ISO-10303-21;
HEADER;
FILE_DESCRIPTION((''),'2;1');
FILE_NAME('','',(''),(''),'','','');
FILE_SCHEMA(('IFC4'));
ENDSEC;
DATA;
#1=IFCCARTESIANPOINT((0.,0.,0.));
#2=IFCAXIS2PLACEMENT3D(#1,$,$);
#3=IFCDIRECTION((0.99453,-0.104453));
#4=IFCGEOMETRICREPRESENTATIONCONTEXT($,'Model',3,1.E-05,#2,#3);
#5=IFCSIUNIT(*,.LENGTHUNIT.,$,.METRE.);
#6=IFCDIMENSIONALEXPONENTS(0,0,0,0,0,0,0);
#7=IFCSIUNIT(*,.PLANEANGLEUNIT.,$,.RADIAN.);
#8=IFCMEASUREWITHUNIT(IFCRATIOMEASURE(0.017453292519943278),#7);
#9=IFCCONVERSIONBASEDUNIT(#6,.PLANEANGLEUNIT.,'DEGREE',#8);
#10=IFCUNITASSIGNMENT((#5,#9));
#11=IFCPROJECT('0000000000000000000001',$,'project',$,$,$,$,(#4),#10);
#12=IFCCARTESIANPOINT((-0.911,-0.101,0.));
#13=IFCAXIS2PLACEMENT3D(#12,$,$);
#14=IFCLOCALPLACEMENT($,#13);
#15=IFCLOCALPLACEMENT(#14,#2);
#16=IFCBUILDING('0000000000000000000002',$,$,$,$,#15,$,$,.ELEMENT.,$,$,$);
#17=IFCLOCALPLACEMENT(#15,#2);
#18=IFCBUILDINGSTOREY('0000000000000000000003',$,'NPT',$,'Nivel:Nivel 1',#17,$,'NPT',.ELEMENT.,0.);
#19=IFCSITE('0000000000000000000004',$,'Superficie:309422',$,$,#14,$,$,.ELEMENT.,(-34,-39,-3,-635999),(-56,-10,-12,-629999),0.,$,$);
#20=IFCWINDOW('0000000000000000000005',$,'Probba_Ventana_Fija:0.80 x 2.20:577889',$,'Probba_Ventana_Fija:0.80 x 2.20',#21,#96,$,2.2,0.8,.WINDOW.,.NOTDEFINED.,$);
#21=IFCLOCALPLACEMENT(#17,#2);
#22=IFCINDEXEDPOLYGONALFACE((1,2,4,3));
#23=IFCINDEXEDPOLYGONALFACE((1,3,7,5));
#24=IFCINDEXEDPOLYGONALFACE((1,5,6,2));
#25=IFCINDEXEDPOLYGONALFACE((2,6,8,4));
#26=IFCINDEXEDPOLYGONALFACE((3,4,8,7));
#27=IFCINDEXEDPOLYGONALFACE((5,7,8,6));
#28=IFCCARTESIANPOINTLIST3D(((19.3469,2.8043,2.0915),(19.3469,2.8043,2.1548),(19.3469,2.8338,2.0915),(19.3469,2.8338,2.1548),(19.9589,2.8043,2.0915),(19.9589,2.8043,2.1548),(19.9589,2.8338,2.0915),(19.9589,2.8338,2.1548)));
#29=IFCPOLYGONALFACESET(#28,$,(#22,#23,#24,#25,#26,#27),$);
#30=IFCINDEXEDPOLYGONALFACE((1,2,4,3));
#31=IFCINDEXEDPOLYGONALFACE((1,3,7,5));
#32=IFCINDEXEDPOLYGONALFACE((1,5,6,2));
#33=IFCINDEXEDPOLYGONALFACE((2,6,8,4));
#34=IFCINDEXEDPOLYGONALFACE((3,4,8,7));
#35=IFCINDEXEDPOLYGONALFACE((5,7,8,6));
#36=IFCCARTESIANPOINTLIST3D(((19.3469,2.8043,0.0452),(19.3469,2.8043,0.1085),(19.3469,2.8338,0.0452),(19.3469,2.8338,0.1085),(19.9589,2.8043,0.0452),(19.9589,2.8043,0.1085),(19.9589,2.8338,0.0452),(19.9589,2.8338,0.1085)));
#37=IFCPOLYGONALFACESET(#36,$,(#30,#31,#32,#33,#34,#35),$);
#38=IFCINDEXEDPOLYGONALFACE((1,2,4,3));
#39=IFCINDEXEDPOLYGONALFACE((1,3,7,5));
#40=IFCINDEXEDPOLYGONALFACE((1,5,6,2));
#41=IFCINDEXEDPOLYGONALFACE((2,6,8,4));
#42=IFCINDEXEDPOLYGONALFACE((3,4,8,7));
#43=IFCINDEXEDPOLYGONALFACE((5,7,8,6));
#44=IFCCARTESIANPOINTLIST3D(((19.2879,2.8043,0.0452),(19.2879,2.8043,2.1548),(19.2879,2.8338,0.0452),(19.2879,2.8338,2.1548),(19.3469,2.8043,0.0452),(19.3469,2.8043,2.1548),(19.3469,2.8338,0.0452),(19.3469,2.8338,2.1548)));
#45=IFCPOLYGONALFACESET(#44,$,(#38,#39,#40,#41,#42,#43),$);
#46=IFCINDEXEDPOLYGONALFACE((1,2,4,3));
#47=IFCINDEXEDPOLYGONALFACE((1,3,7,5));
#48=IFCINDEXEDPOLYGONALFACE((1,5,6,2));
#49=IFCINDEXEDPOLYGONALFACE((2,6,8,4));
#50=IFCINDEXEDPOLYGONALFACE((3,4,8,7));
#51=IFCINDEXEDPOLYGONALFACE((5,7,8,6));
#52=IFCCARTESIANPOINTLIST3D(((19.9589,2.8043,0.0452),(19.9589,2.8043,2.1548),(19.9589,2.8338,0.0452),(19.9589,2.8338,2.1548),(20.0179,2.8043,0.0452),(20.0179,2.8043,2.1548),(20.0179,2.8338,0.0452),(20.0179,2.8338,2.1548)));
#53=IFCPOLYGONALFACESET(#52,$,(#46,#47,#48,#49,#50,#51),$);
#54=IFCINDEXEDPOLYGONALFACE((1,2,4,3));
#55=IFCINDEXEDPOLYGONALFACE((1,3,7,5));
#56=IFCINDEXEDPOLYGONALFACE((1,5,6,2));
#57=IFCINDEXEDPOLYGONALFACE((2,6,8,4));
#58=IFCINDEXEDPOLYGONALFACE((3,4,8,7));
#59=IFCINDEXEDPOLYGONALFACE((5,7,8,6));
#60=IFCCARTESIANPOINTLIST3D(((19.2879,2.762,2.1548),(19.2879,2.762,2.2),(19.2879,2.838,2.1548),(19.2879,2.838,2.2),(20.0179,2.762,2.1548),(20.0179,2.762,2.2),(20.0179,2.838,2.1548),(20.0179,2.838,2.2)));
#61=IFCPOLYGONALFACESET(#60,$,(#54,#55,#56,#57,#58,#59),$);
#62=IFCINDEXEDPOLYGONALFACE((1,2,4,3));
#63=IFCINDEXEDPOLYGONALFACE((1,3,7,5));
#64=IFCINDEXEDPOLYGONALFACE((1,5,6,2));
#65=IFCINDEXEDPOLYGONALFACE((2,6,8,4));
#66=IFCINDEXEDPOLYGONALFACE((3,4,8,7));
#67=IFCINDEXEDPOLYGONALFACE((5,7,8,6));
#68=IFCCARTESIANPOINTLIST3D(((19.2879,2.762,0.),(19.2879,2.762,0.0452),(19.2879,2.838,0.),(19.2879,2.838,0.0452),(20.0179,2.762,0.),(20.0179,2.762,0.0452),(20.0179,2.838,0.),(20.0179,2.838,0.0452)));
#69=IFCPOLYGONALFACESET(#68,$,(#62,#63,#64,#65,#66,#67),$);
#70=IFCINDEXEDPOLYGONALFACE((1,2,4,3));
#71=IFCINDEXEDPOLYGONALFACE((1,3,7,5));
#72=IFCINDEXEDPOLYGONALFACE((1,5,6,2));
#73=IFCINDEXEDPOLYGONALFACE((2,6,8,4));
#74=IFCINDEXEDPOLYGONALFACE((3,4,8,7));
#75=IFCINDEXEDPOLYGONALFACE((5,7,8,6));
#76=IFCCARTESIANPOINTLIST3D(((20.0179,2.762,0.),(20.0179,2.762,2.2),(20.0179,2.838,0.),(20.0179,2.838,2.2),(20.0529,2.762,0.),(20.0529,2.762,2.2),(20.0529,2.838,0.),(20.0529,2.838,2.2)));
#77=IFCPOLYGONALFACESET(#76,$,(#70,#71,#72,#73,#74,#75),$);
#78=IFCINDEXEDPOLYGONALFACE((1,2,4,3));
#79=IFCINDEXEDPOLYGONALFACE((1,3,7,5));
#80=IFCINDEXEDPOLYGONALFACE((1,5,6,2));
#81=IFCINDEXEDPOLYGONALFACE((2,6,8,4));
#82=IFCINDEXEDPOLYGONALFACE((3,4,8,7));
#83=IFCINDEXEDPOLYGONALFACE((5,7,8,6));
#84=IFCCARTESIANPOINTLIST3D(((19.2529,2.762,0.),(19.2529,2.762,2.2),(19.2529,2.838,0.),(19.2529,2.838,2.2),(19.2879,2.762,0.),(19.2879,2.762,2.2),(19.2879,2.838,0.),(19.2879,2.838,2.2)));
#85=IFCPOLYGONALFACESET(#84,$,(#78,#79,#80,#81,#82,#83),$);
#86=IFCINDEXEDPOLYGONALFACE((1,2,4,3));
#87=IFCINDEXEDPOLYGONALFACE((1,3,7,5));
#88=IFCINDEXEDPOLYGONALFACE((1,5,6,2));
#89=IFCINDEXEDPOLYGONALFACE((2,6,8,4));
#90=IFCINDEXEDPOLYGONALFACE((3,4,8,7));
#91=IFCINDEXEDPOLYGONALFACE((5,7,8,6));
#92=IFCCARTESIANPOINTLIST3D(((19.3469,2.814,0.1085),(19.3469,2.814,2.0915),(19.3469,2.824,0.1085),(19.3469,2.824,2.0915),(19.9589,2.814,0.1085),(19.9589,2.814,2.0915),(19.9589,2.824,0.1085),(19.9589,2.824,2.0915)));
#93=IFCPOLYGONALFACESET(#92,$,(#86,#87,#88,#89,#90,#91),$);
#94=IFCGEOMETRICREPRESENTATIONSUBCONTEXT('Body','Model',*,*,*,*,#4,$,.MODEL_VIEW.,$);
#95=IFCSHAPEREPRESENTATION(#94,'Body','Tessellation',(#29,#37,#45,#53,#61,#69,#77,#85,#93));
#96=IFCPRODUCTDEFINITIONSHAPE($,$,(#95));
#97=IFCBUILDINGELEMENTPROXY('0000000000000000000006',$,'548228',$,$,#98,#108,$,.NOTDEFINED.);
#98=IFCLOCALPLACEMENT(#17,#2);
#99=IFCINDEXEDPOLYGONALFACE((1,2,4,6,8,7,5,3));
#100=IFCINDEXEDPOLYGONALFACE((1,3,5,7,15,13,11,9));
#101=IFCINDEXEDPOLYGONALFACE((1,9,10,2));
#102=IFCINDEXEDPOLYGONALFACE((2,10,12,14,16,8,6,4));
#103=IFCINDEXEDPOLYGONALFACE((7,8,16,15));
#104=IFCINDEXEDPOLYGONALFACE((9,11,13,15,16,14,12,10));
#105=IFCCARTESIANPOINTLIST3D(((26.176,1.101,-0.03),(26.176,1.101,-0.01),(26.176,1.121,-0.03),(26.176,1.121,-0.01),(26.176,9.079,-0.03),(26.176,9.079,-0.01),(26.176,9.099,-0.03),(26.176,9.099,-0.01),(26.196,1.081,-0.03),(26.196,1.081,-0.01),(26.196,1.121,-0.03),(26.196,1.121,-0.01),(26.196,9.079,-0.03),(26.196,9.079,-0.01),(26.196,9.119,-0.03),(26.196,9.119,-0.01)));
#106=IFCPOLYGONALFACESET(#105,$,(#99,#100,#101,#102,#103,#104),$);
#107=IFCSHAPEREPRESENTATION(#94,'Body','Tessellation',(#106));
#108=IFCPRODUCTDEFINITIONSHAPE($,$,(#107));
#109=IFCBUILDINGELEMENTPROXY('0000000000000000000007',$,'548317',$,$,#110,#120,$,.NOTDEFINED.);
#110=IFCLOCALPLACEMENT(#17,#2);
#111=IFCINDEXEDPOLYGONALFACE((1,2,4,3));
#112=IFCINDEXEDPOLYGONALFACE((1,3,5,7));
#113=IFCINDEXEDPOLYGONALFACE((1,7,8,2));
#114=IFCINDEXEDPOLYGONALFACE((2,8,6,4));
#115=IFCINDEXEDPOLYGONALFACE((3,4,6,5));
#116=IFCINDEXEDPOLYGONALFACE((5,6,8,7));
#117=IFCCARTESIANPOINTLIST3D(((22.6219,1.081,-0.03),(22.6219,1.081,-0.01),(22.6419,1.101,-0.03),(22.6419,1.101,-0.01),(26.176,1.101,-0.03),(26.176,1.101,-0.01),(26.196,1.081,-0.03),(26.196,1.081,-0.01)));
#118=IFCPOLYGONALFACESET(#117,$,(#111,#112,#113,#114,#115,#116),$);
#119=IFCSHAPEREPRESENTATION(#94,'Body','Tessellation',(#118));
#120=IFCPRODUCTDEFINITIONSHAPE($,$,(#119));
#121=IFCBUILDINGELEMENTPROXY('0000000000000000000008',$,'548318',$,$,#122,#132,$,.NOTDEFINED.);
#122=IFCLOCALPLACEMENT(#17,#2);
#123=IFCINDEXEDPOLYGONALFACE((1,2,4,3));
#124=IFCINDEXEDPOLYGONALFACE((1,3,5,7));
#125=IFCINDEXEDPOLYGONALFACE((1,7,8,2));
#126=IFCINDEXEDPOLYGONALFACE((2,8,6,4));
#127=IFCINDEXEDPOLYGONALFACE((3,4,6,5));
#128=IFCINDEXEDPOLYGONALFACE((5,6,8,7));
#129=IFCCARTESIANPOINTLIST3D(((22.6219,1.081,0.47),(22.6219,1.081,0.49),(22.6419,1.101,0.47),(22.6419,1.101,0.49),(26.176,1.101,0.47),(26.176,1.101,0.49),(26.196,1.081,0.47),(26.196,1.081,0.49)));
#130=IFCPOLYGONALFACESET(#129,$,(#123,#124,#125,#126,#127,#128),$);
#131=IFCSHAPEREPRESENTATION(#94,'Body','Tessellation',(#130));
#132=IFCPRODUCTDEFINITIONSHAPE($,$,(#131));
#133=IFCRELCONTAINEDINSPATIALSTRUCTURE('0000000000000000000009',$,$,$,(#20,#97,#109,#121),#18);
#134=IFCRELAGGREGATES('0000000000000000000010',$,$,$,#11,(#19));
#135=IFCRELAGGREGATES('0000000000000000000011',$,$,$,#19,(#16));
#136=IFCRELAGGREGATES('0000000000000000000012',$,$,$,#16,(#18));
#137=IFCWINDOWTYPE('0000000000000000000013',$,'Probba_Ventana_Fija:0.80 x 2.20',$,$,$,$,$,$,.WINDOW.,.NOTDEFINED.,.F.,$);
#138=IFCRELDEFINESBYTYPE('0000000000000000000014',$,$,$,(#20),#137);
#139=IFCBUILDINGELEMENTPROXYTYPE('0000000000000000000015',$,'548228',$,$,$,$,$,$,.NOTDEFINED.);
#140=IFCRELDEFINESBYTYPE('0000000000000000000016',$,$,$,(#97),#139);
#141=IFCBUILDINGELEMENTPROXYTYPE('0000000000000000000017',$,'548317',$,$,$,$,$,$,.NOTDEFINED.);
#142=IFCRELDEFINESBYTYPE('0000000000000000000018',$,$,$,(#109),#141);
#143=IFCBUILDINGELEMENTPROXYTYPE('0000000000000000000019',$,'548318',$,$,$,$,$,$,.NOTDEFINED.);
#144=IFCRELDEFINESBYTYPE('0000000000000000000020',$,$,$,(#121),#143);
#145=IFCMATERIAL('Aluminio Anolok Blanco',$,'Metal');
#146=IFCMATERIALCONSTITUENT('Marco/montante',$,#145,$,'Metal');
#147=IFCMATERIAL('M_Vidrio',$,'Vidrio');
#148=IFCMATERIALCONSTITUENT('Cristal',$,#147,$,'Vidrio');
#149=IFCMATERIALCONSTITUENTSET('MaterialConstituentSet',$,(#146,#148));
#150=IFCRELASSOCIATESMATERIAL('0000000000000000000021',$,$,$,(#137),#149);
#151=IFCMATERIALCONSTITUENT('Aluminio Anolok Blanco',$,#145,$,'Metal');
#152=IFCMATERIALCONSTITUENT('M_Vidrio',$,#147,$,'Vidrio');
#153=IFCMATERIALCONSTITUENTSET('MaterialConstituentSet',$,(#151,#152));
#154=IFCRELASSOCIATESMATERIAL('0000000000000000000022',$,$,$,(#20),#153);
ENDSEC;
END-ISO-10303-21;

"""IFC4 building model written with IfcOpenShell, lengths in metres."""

from ifc_helpers import new_model, entity, si_unit, converted_unit, direction, frame, frame_2d, origin, origin_2d_with_axis, place, context, subcontext, project, spatial, polyline, rectangle, outline, extrude, source, transform, mapped, material, constituent, constituent_set, type_object, type_shapes, element, save


model = new_model("IFC4")

# Units and contexts
model_context = context("Model", 3, precision=1e-05, world=origin(), true_north=direction((0.99453, -0.104453)))
body_context = subcontext(model_context, "Body", "Model", "MODEL_VIEW")
ifc_project = project(units=[si_unit("LENGTHUNIT", "METRE"), converted_unit("PLANEANGLEUNIT", "DEGREE", entity("IfcRatioMeasure", 0.017453292519943278), si_unit("PLANEANGLEUNIT", "RADIAN"), dimensions=[0, 0, 0, 0, 0, 0, 0])], contexts=[model_context])

# Site, building, storey
site_placement = place(None, frame((-0.911, -0.101, 0.0)))
site = spatial("IfcSite", under=ifc_project, at=site_placement, Name="Superficie:309422", CompositionType="ELEMENT", RefLatitude=(-34, -39, -3, -635999), RefLongitude=(-56, -10, -12, -629999), RefElevation=0.0)
building_placement = place(site_placement, origin())
building = spatial("IfcBuilding", under=site, at=building_placement, CompositionType="ELEMENT")
storey_placement = place(building_placement, origin())
storey = spatial("IfcBuildingStorey", under=building, at=storey_placement, Name="NPT", ObjectType="Nivel:Nivel 1", LongName="NPT", CompositionType="ELEMENT", Elevation=0.0)

# Window
ifc_material_1 = material(Name="Aluminio Anolok Blanco", Category="Metal")
ifc_constituent_1 = constituent(ifc_material_1, Name="Aluminio Anolok Blanco", Category="Metal")
ifc_material_2 = material(Name="M_Vidrio", Category="Vidrio")
ifc_constituent_2 = constituent(ifc_material_2, Name="M_Vidrio", Category="Vidrio")
ifc_constituent_set_1 = constituent_set(constituents=[ifc_constituent_1, ifc_constituent_2], Name="MaterialConstituentSet")
ifc_constituent_3 = constituent(ifc_material_1, Name="Marco/montante", Category="Metal")
ifc_constituent_4 = constituent(ifc_material_2, Name="Cristal", Category="Vidrio")
ifc_constituent_set_2 = constituent_set(constituents=[ifc_constituent_3, ifc_constituent_4], Name="MaterialConstituentSet")
window_type = type_object("IfcWindowType", Name="Probba_Ventana_Fija:0.80 x 2.20", ParameterTakesPrecedence=False, PartitioningType="NOTDEFINED", PredefinedType="WINDOW", material=ifc_constituent_set_2)
shared_shape_1 = source(origin(), body_context, "Body", "SweptSolid", [
    extrude(rectangle(XDim=0.612, YDim=0.0295, at=frame_2d((0.0, 0.0), x_axis=(1.0, 0.0))), frame((0.4, 0.019, 2.0915)), (0.0, 0.0, 1.0), 0.0633),
    extrude(rectangle(XDim=0.612, YDim=0.0295, at=frame_2d((0.0, 0.0), x_axis=(1.0, 0.0))), frame((0.4, 0.019, 0.0452)), (0.0, 0.0, 1.0), 0.0633),
    extrude(rectangle(XDim=0.0295, YDim=0.059, at=origin_2d_with_axis()), frame((0.7355, 0.019, 0.0452), z_axis=(0.0, 0.0, 1.0), x_axis=(0.0, 1.0, 0.0)), (0.0, 0.0, 1.0), 2.1096),
    extrude(rectangle(XDim=0.0295, YDim=0.059, at=origin_2d_with_axis()), frame((0.0645, 0.019, 0.0452), z_axis=(0.0, 0.0, 1.0), x_axis=(0.0, 1.0, 0.0)), (0.0, 0.0, 1.0), 2.1096),
    extrude(rectangle(XDim=0.73, YDim=0.076, at=origin_2d_with_axis()), frame((0.4, 0.038, 2.1548)), (0.0, 0.0, 1.0), 0.0452),
    extrude(rectangle(XDim=0.73, YDim=0.076, at=origin_2d_with_axis()), frame((0.4, 0.038, 0.0)), (0.0, 0.0, 1.0), 0.0452),
    extrude(rectangle(XDim=0.035, YDim=0.076, at=origin_2d_with_axis()), frame((0.0175, 0.038, 0.0), z_axis=(0.0, 0.0, 1.0), x_axis=(-1.0, 0.0, 0.0)), (0.0, 0.0, 1.0), 2.2),
    extrude(rectangle(XDim=0.035, YDim=0.076, at=origin_2d_with_axis()), frame((0.7825, 0.038, 0.0), z_axis=(0.0, 0.0, 1.0), x_axis=(-1.0, 0.0, 0.0)), (0.0, 0.0, 1.0), 2.2),
    extrude(rectangle(XDim=0.01, YDim=0.612, at=frame_2d((0.0, 0.0), x_axis=(1.0, 0.0))), frame((0.4, 0.019, 0.1085), z_axis=(0.0, 0.0, 1.0), x_axis=(0.0, 1.0, 0.0)), (0.0, 0.0, 1.0), 1.983),
])
type_shapes(window_type, [shared_shape_1])
window_placement = place(storey_placement, frame((20.0529, 2.838, 0.0), z_axis=(0.0, 0.0, 1.0), x_axis=(-1.0, 0.0, 0.0)))
element("IfcWindow", 1, at=window_placement, inside=storey, type_object=window_type, material=ifc_constituent_set_1, Name="Probba_Ventana_Fija:0.80 x 2.20:577889", ObjectType="Probba_Ventana_Fija:0.80 x 2.20", OverallHeight=2.2, OverallWidth=0.8, PartitioningType="NOTDEFINED", PredefinedType="WINDOW", context=body_context, shape_type="MappedRepresentation", body=[
    mapped(shared_shape_1, transform((0.0, 0.0, 0.0), scale=1.0)),
])

# Building element proxies
building_element_proxy_type_1 = type_object("IfcBuildingElementProxyType", Name="548228", PredefinedType="NOTDEFINED")
proxy_1_placement = place(storey_placement, frame((26.176, 1.081, -0.03)))
element("IfcBuildingElementProxy", 2, at=proxy_1_placement, inside=storey, type_object=building_element_proxy_type_1, Name="548228", PredefinedType="NOTDEFINED", context=body_context, shape_type="SweptSolid", body=[
    extrude(outline(polyline([(-3.999, -0.01), (-3.979, -0.01), (3.979, -0.01), (3.999, -0.01), (4.019, 0.01), (3.979, 0.01), (-3.979, 0.01), (-4.019, 0.01), (-3.999, -0.01)])), frame((0.01, 4.019, 0.0), z_axis=(0.0, 0.0, 1.0), x_axis=(0.0, -1.0, 0.0)), (0.0, 0.0, 1.0), 0.02),
])
building_element_proxy_type_2 = type_object("IfcBuildingElementProxyType", Name="548317", PredefinedType="NOTDEFINED")
proxy_2_placement = place(storey_placement, frame((22.6219, 1.081, -0.03)))
element("IfcBuildingElementProxy", 3, at=proxy_2_placement, inside=storey, type_object=building_element_proxy_type_2, Name="548317", PredefinedType="NOTDEFINED", context=body_context, shape_type="SweptSolid", body=[
    extrude(outline(polyline([(-1.767, -0.01), (1.767, -0.01), (1.787, 0.01), (-1.787, 0.01), (-1.767, -0.01)])), frame((1.787, 0.01, 0.0), z_axis=(0.0, 0.0, 1.0), x_axis=(-1.0, 0.0, 0.0)), (0.0, 0.0, 1.0), 0.02),
])
building_element_proxy_type_3 = type_object("IfcBuildingElementProxyType", Name="548318", PredefinedType="NOTDEFINED")
proxy_3_placement = place(storey_placement, frame((22.6219, 1.081, 0.47)))
element("IfcBuildingElementProxy", 4, at=proxy_3_placement, inside=storey, type_object=building_element_proxy_type_3, Name="548318", PredefinedType="NOTDEFINED", context=body_context, shape_type="SweptSolid", body=[
    extrude(outline(polyline([(-1.767, -0.01), (1.767, -0.01), (1.787, 0.01), (-1.787, 0.01), (-1.767, -0.01)])), frame((1.787, 0.01, 0.0), z_axis=(0.0, 0.0, 1.0), x_axis=(-1.0, 0.0, 0.0)), (0.0, 0.0, 1.0), 0.02),
])

save(model, "model.ifc")
